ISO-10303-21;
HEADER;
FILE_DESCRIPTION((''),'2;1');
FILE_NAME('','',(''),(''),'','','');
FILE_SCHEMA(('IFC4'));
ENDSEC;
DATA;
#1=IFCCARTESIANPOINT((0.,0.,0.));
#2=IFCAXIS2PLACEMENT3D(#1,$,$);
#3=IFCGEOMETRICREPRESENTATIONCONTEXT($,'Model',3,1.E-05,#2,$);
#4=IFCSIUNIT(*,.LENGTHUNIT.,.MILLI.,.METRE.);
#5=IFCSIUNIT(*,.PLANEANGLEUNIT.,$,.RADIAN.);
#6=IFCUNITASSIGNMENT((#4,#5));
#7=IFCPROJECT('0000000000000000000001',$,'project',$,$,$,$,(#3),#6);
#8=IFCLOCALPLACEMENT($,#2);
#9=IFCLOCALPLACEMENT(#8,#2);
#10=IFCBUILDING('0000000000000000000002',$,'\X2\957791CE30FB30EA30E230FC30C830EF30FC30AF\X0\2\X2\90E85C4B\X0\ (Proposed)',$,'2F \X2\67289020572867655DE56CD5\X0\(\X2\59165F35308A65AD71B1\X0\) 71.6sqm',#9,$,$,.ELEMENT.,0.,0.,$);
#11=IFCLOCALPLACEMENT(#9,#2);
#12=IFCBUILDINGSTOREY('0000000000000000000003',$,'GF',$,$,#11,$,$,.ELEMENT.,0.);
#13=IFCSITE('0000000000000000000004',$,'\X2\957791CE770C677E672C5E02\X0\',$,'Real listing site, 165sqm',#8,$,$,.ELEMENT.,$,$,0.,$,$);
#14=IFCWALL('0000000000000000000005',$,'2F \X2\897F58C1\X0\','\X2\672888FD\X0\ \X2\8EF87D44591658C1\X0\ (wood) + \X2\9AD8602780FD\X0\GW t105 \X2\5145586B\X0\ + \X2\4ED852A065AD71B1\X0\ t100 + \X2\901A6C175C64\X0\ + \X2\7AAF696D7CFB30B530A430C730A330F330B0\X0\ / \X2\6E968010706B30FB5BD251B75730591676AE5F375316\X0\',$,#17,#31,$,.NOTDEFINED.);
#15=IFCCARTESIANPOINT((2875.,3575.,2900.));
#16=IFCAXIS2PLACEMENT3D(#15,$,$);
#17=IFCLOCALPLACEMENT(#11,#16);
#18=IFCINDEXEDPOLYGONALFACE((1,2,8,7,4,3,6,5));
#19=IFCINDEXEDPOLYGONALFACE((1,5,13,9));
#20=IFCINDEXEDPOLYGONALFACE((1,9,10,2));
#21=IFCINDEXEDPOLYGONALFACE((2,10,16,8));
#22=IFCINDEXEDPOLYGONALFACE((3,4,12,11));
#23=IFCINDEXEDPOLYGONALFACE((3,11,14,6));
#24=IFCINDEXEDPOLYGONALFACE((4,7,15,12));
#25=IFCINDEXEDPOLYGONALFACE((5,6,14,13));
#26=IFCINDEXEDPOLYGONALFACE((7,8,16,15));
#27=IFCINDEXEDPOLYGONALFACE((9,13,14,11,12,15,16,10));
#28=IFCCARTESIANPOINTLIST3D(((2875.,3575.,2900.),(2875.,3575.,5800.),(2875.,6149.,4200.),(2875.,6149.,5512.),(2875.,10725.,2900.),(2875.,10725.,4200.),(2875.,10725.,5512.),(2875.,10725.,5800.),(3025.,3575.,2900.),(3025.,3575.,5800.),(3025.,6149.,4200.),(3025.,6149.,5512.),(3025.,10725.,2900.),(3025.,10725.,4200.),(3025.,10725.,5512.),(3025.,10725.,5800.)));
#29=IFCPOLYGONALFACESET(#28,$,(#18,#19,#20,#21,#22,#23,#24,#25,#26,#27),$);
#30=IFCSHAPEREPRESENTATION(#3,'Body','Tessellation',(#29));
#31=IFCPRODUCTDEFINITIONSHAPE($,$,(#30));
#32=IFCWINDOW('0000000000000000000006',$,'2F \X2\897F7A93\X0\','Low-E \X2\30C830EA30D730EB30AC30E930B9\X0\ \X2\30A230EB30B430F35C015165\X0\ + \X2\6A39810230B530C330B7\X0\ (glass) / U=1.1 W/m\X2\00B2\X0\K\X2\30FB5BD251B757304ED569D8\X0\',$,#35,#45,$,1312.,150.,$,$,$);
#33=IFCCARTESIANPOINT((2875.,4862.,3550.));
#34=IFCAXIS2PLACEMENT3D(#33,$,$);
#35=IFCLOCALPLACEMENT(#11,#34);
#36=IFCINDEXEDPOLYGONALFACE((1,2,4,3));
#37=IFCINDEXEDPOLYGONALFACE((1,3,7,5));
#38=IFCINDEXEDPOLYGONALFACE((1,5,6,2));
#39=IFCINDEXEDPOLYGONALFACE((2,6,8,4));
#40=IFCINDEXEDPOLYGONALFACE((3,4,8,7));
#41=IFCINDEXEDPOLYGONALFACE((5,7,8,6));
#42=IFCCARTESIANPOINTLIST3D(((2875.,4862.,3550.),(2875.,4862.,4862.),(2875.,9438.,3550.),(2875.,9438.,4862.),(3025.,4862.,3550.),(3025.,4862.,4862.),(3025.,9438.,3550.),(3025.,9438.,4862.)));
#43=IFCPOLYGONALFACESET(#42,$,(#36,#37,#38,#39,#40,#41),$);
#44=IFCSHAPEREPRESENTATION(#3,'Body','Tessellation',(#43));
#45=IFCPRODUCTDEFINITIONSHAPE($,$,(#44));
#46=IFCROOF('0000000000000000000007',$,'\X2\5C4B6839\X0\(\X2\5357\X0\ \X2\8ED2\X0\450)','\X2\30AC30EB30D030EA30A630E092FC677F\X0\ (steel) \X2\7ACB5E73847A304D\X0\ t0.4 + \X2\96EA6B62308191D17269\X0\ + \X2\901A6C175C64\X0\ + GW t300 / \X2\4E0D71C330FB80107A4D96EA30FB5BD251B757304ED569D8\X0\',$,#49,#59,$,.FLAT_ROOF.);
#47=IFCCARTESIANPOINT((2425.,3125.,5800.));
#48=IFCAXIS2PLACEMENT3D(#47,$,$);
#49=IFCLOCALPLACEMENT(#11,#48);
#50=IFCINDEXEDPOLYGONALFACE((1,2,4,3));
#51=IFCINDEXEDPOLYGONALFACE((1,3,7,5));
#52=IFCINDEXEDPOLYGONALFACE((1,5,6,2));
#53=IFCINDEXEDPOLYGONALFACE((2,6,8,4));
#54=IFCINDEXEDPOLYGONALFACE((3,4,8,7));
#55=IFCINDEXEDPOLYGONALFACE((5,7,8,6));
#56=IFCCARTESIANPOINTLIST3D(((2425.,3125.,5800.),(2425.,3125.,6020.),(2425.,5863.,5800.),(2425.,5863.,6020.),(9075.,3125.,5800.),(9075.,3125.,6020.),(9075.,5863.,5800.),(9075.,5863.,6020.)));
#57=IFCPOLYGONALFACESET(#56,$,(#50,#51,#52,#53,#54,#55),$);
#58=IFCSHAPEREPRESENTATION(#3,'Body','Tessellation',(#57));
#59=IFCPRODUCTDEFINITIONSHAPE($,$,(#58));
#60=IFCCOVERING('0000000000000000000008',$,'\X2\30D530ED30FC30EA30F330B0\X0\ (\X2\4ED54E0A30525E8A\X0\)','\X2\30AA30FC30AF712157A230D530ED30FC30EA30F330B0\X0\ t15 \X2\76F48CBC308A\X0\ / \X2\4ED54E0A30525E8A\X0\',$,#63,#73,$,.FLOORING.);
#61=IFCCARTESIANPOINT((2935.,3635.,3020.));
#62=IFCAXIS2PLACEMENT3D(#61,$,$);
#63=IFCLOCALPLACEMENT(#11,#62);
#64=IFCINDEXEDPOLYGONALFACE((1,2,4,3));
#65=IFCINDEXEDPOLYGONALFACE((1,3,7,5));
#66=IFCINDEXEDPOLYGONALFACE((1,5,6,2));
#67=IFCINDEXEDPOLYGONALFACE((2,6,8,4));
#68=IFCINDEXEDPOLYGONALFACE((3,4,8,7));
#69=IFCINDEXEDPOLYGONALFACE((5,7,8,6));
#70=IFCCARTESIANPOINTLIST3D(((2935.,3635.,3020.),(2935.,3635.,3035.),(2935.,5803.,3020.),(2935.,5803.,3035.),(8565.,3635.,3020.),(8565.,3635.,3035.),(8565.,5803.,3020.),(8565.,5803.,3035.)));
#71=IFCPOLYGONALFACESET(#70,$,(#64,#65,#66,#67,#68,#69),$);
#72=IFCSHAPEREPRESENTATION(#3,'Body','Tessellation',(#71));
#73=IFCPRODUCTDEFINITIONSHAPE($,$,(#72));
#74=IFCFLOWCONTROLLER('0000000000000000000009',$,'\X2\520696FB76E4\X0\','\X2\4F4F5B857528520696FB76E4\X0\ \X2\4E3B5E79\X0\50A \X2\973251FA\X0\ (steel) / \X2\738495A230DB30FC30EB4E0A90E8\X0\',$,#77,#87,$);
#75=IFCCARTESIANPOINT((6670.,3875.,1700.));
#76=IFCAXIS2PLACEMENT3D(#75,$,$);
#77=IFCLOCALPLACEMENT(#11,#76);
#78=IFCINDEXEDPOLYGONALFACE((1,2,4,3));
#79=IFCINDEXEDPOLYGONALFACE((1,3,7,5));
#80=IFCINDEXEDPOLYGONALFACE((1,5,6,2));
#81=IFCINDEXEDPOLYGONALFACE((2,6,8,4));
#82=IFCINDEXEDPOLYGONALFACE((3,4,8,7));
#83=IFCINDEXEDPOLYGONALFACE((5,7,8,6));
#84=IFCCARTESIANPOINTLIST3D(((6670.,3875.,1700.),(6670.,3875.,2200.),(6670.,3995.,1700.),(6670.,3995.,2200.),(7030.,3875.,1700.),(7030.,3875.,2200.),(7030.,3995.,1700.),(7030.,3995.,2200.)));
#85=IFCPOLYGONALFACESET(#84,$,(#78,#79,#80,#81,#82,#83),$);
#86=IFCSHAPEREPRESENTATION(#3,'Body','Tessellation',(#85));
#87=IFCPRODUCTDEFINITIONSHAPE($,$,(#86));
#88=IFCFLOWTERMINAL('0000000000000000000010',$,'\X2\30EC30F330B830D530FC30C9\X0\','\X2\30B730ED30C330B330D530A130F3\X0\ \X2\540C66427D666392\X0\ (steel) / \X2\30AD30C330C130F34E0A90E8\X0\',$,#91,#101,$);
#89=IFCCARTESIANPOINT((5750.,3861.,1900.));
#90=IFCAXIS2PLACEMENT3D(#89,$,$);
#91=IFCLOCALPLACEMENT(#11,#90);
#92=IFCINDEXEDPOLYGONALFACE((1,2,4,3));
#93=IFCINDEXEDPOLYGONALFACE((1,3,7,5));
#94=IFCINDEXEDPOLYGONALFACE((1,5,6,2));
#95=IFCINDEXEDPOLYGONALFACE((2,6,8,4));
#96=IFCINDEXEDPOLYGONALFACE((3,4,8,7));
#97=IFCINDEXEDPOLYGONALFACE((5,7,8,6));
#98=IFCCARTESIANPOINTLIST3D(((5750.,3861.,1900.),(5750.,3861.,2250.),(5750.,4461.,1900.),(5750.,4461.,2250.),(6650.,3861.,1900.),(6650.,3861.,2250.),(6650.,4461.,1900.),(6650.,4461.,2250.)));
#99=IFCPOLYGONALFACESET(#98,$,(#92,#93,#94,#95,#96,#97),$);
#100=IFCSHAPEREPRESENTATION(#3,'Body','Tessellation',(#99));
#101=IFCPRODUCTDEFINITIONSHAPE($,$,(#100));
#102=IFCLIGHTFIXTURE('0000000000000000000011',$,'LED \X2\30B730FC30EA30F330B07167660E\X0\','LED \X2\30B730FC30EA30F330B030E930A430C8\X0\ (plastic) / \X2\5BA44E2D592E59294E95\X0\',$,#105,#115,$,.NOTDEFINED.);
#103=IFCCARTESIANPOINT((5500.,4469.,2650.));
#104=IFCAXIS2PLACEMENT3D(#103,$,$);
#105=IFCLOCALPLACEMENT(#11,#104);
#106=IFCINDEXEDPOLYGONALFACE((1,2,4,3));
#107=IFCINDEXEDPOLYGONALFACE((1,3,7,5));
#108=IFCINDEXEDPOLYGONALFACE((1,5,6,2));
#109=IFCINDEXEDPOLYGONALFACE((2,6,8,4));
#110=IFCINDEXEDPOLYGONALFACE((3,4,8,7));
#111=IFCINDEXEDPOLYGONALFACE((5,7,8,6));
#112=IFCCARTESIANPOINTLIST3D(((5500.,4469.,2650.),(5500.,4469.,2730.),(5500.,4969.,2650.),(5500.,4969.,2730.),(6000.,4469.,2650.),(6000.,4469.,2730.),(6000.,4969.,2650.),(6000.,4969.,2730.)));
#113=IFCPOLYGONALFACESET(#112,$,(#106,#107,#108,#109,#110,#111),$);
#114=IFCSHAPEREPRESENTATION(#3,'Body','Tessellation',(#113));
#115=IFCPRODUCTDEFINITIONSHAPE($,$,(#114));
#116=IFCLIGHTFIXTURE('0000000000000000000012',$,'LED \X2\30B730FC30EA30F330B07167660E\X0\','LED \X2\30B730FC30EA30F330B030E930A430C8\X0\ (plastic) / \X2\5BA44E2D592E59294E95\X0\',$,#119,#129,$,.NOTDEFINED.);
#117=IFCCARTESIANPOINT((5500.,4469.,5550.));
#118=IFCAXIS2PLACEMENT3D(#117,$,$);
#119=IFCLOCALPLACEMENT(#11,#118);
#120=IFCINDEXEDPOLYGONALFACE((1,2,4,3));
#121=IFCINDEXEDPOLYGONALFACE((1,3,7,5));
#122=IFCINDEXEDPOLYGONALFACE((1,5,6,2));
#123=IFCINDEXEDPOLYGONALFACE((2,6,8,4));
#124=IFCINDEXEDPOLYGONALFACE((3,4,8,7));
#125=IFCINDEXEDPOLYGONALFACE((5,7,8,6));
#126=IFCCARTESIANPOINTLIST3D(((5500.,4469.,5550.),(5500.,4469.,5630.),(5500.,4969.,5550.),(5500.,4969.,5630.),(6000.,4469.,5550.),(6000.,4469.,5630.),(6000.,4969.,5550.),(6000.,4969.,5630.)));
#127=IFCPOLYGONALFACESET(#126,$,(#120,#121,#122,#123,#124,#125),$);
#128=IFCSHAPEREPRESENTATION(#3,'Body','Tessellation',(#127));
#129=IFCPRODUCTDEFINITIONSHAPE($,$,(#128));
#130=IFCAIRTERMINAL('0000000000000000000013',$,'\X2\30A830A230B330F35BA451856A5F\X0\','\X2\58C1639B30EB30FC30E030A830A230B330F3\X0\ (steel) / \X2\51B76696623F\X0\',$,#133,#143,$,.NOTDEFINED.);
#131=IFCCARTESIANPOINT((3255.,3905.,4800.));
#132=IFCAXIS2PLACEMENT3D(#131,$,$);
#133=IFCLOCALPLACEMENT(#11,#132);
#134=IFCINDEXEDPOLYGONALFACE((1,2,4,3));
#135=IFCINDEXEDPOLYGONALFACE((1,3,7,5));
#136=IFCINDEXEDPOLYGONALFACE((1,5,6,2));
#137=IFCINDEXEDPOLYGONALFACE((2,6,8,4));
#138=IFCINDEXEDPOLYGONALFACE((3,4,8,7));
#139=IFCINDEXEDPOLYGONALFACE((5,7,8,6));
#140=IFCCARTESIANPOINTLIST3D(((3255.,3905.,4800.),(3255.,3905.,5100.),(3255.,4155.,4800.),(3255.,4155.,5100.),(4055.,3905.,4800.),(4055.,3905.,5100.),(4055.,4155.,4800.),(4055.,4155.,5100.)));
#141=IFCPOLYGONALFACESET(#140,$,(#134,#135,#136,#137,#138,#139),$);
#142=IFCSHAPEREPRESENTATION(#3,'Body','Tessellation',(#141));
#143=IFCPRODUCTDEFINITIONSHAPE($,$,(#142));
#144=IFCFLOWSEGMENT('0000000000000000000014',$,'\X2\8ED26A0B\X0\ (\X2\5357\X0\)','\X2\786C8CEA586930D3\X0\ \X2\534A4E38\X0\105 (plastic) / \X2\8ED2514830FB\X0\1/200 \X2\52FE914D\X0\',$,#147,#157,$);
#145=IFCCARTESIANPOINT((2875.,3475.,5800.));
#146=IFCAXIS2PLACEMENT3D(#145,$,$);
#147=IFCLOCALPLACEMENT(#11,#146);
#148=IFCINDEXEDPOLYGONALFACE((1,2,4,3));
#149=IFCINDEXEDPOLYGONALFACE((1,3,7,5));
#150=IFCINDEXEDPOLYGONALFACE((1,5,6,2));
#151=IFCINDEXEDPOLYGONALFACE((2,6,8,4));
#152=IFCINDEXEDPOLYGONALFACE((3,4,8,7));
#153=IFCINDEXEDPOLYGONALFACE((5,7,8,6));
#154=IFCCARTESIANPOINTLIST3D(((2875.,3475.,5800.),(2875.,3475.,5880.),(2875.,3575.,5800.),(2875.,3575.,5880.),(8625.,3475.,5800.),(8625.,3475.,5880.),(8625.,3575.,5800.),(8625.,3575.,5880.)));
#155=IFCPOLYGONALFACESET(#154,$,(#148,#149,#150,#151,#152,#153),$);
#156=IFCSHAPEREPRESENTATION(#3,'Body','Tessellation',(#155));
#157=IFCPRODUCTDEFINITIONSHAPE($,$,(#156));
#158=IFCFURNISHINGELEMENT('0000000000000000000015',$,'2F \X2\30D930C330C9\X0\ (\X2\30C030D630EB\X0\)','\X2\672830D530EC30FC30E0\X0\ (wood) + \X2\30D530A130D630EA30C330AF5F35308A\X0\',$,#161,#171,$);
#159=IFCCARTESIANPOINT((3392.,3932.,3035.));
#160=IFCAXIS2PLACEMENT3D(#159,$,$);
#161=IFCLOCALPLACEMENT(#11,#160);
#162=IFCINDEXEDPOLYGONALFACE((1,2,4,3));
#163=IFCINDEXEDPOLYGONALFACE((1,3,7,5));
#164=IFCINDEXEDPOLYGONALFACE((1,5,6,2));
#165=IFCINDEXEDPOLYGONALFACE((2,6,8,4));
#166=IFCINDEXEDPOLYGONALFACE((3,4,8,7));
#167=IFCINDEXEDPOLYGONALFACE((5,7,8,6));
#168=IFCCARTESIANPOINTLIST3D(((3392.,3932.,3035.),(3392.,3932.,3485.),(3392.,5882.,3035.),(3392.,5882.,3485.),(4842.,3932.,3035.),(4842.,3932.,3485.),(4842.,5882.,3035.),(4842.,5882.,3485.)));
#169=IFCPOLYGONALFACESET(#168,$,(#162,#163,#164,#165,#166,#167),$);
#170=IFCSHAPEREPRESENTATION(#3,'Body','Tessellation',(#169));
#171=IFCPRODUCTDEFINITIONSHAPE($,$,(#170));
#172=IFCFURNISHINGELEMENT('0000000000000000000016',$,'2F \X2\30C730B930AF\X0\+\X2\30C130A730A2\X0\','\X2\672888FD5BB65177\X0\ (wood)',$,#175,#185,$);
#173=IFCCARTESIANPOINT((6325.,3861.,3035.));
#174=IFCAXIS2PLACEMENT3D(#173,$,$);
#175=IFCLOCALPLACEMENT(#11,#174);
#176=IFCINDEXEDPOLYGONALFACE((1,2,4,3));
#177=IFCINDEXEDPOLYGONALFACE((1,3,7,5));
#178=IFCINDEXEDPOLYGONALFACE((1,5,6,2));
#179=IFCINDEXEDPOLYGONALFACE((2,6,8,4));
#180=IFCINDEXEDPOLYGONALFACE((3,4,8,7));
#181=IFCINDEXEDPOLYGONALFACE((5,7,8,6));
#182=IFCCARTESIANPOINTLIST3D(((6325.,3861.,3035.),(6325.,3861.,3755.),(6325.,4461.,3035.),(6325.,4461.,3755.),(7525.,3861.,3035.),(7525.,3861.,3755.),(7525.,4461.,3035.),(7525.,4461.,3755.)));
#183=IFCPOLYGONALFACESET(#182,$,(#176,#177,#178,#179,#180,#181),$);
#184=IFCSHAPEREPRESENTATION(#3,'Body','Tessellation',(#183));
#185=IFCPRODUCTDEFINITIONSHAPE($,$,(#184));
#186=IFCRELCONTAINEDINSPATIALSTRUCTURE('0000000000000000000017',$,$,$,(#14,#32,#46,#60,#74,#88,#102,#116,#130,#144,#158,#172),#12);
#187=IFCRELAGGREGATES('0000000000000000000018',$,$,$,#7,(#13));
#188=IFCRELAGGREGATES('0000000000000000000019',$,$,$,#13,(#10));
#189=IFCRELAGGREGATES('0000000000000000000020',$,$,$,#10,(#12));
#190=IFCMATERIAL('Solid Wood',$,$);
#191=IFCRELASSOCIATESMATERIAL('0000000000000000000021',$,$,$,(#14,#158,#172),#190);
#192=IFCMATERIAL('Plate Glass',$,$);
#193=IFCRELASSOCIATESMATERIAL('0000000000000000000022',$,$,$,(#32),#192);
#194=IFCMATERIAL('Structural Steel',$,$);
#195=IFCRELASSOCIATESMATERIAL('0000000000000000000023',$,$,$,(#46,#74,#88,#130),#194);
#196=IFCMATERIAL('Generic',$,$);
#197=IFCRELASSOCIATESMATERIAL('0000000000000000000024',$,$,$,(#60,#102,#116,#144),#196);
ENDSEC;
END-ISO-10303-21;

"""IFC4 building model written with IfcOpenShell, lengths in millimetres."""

from ifc_helpers import new_model, si_unit, frame, frame_2d, origin, place, context, project, spatial, rectangle, extrude, material, element, fill, save


model = new_model("IFC4")

# Units and contexts
model_context = context("Model", 3, precision=1e-05, world=origin())
ifc_project = project(units=[si_unit("LENGTHUNIT", "METRE", prefix="MILLI"), si_unit("PLANEANGLEUNIT", "RADIAN")], contexts=[model_context])

# Site, building, storey
site_placement = place(None, origin())
site = spatial("IfcSite", under=ifc_project, at=site_placement, Name="長野県松本市", ObjectType="Real listing site, 165sqm", CompositionType="ELEMENT", RefElevation=0.0)
building_placement = place(site_placement, origin())
building = spatial("IfcBuilding", under=site, at=building_placement, Name="長野・リモートワーク2部屋 (Proposed)", ObjectType="2F 木造在来工法(外張り断熱) 71.6sqm", CompositionType="ELEMENT", ElevationOfRefHeight=0.0, ElevationOfTerrain=0.0)
storey_placement = place(building_placement, origin())
storey = spatial("IfcBuildingStorey", under=building, at=storey_placement, Name="GF", CompositionType="ELEMENT", Elevation=0.0)

# Shared definitions
ifc_material_1 = material(Name="Solid Wood")

# Wall, opening, window
ifc_material_2 = material(Name="Plate Glass")
wall_1_placement = place(storey_placement, frame((2875.0, 3575.0, 2900.0)))
wall_1 = element("IfcWall", 1, at=wall_1_placement, inside=storey, material=ifc_material_1, Name="2F 西壁", Description="木製 軸組外壁 (wood) + 高性能GW t105 充填 + 付加断熱 t100 + 通気層 + 窯業系サイディング / 準耐火・寒冷地外皮強化", PredefinedType="NOTDEFINED", context=model_context, shape_type="SweptSolid", body=[
    extrude(rectangle(XDim=150.0, YDim=7150.0, at=frame_2d((75.0, 3575.0))), frame((2875.0, 3575.0, 2900.0)), (0.0, 0.0, 1.0), 2900.0),
])
opening_1_placement = place(storey_placement, frame((2875.0, 4862.0, 3550.0)))
opening_1 = element("IfcOpeningElement", 2, at=opening_1_placement, cuts=wall_1, PredefinedType="NOTDEFINED", context=model_context, shape_type="SweptSolid", body=[
    extrude(rectangle(XDim=150.0, YDim=4576.0, at=frame_2d((75.0, 2288.0))), frame((2875.0, 4862.0, 3550.0)), (0.0, 0.0, 1.0), 1312.0),
])
window_1_placement = place(storey_placement, frame((2875.0, 4862.0, 3550.0)))
window_1 = element("IfcWindow", 3, at=window_1_placement, inside=storey, material=ifc_material_2, Name="2F 西窓", Description="Low-E トリプルガラス アルゴン封入 + 樹脂サッシ (glass) / U=1.1 W/m²K・寒冷地仕様", OverallHeight=1312.0, OverallWidth=150.0, context=model_context, shape_type="SweptSolid", body=[
    extrude(rectangle(XDim=150.0, YDim=4576.0, at=frame_2d((75.0, 2288.0))), frame((2875.0, 4862.0, 3550.0)), (0.0, 0.0, 1.0), 1312.0),
])
fill(opening_1, window_1)

# Roof
ifc_material_3 = material(Name="Structural Steel")
for number, where, name in (
    (4, (2425.0, 3125.0, 5800.0), "屋根(南 軒450)"),
):
    element("IfcRoof", number, at=place(storey_placement, frame(where)), inside=storey, material=ifc_material_3, Name=name, Description="ガルバリウム鋼板 (steel) 立平葺き t0.4 + 雪止め金物 + 通気層 + GW t300 / 不燃・耐積雪・寒冷地仕様", PredefinedType="FLAT_ROOF", context=model_context, shape_type="SweptSolid", body=[
        extrude(rectangle(XDim=6650.0, YDim=2738.0, at=frame_2d((3325.0, 1369.0))), frame((2425.0, 3125.0, 5800.0)), (0.0, 0.0, 1.0), 220.0),
    ])

# Covering
ifc_material_4 = material(Name="Generic")
covering_placement = place(storey_placement, frame((2935.0, 3635.0, 3020.0)))
element("IfcCovering", 5, at=covering_placement, inside=storey, material=ifc_material_4, Name="フローリング (仕上げ床)", Description="オーク無垢フローリング t15 直貼り / 仕上げ床", PredefinedType="FLOORING", context=model_context, shape_type="SweptSolid", body=[
    extrude(rectangle(XDim=5630.0, YDim=2168.0, at=frame_2d((2815.0, 1084.0))), frame((2935.0, 3635.0, 3020.0)), (0.0, 0.0, 1.0), 15.0),
])

# Flow controller
flow_controller_placement = place(storey_placement, frame((6670.0, 3875.0, 1700.0)))
element("IfcFlowController", 6, at=flow_controller_placement, inside=storey, material=ifc_material_3, Name="分電盤", Description="住宅用分電盤 主幹50A 露出 (steel) / 玄関ホール上部", context=model_context, shape_type="SweptSolid", body=[
    extrude(rectangle(XDim=360.0, YDim=120.0, at=frame_2d((180.0, 60.0))), frame((6670.0, 3875.0, 1700.0)), (0.0, 0.0, 1.0), 500.0),
])

# Flow terminal
flow_terminal_placement = place(storey_placement, frame((5750.0, 3861.0, 1900.0)))
element("IfcFlowTerminal", 7, at=flow_terminal_placement, inside=storey, material=ifc_material_3, Name="レンジフード", Description="シロッコファン 同時給排 (steel) / キッチン上部", context=model_context, shape_type="SweptSolid", body=[
    extrude(rectangle(XDim=900.0, YDim=600.0, at=frame_2d((450.0, 300.0))), frame((5750.0, 3861.0, 1900.0)), (0.0, 0.0, 1.0), 350.0),
])

# Light fixtures
light_fixture_1_placement = place(storey_placement, frame((5500.0, 4469.0, 2650.0)))
element("IfcLightFixture", 8, at=light_fixture_1_placement, inside=storey, material=ifc_material_4, Name="LED シーリング照明", Description="LED シーリングライト (plastic) / 室中央天井", PredefinedType="NOTDEFINED", context=model_context, shape_type="SweptSolid", body=[
    extrude(rectangle(XDim=500.0, YDim=500.0, at=frame_2d((250.0, 250.0))), frame((5500.0, 4469.0, 2650.0)), (0.0, 0.0, 1.0), 80.0),
])
light_fixture_2_placement = place(storey_placement, frame((5500.0, 4469.0, 5550.0)))
element("IfcLightFixture", 9, at=light_fixture_2_placement, inside=storey, material=ifc_material_4, Name="LED シーリング照明", Description="LED シーリングライト (plastic) / 室中央天井", PredefinedType="NOTDEFINED", context=model_context, shape_type="SweptSolid", body=[
    extrude(rectangle(XDim=500.0, YDim=500.0, at=frame_2d((250.0, 250.0))), frame((5500.0, 4469.0, 5550.0)), (0.0, 0.0, 1.0), 80.0),
])

# Air terminal
air_terminal_placement = place(storey_placement, frame((3255.0, 3905.0, 4800.0)))
element("IfcAirTerminal", 10, at=air_terminal_placement, inside=storey, material=ifc_material_3, Name="エアコン室内機", Description="壁掛ルームエアコン (steel) / 冷暖房", PredefinedType="NOTDEFINED", context=model_context, shape_type="SweptSolid", body=[
    extrude(rectangle(XDim=800.0, YDim=250.0, at=frame_2d((400.0, 125.0))), frame((3255.0, 3905.0, 4800.0)), (0.0, 0.0, 1.0), 300.0),
])

# Flow segment
flow_segment_placement = place(storey_placement, frame((2875.0, 3475.0, 5800.0)))
element("IfcFlowSegment", 11, at=flow_segment_placement, inside=storey, material=ifc_material_4, Name="軒樋 (南)", Description="硬質塩ビ 半丸105 (plastic) / 軒先・1/200 勾配", context=model_context, shape_type="SweptSolid", body=[
    extrude(rectangle(XDim=5750.0, YDim=100.0, at=frame_2d((2875.0, 50.0))), frame((2875.0, 3475.0, 5800.0)), (0.0, 0.0, 1.0), 80.0),
])

# Furnishing elements
furnishing_1_placement = place(storey_placement, frame((3392.0, 3932.0, 3035.0)))
element("IfcFurnishingElement", 12, at=furnishing_1_placement, inside=storey, material=ifc_material_1, Name="2F ベッド (ダブル)", Description="木フレーム (wood) + ファブリック張り", context=model_context, shape_type="SweptSolid", body=[
    extrude(rectangle(XDim=1450.0, YDim=1950.0, at=frame_2d((725.0, 975.0))), frame((3392.0, 3932.0, 3035.0)), (0.0, 0.0, 1.0), 450.0),
])
furnishing_2_placement = place(storey_placement, frame((6325.0, 3861.0, 3035.0)))
element("IfcFurnishingElement", 13, at=furnishing_2_placement, inside=storey, material=ifc_material_1, Name="2F デスク+チェア", Description="木製家具 (wood)", context=model_context, shape_type="SweptSolid", body=[
    extrude(rectangle(XDim=1200.0, YDim=600.0, at=frame_2d((600.0, 300.0))), frame((6325.0, 3861.0, 3035.0)), (0.0, 0.0, 1.0), 720.0),
])

save(model, "model.ifc")
